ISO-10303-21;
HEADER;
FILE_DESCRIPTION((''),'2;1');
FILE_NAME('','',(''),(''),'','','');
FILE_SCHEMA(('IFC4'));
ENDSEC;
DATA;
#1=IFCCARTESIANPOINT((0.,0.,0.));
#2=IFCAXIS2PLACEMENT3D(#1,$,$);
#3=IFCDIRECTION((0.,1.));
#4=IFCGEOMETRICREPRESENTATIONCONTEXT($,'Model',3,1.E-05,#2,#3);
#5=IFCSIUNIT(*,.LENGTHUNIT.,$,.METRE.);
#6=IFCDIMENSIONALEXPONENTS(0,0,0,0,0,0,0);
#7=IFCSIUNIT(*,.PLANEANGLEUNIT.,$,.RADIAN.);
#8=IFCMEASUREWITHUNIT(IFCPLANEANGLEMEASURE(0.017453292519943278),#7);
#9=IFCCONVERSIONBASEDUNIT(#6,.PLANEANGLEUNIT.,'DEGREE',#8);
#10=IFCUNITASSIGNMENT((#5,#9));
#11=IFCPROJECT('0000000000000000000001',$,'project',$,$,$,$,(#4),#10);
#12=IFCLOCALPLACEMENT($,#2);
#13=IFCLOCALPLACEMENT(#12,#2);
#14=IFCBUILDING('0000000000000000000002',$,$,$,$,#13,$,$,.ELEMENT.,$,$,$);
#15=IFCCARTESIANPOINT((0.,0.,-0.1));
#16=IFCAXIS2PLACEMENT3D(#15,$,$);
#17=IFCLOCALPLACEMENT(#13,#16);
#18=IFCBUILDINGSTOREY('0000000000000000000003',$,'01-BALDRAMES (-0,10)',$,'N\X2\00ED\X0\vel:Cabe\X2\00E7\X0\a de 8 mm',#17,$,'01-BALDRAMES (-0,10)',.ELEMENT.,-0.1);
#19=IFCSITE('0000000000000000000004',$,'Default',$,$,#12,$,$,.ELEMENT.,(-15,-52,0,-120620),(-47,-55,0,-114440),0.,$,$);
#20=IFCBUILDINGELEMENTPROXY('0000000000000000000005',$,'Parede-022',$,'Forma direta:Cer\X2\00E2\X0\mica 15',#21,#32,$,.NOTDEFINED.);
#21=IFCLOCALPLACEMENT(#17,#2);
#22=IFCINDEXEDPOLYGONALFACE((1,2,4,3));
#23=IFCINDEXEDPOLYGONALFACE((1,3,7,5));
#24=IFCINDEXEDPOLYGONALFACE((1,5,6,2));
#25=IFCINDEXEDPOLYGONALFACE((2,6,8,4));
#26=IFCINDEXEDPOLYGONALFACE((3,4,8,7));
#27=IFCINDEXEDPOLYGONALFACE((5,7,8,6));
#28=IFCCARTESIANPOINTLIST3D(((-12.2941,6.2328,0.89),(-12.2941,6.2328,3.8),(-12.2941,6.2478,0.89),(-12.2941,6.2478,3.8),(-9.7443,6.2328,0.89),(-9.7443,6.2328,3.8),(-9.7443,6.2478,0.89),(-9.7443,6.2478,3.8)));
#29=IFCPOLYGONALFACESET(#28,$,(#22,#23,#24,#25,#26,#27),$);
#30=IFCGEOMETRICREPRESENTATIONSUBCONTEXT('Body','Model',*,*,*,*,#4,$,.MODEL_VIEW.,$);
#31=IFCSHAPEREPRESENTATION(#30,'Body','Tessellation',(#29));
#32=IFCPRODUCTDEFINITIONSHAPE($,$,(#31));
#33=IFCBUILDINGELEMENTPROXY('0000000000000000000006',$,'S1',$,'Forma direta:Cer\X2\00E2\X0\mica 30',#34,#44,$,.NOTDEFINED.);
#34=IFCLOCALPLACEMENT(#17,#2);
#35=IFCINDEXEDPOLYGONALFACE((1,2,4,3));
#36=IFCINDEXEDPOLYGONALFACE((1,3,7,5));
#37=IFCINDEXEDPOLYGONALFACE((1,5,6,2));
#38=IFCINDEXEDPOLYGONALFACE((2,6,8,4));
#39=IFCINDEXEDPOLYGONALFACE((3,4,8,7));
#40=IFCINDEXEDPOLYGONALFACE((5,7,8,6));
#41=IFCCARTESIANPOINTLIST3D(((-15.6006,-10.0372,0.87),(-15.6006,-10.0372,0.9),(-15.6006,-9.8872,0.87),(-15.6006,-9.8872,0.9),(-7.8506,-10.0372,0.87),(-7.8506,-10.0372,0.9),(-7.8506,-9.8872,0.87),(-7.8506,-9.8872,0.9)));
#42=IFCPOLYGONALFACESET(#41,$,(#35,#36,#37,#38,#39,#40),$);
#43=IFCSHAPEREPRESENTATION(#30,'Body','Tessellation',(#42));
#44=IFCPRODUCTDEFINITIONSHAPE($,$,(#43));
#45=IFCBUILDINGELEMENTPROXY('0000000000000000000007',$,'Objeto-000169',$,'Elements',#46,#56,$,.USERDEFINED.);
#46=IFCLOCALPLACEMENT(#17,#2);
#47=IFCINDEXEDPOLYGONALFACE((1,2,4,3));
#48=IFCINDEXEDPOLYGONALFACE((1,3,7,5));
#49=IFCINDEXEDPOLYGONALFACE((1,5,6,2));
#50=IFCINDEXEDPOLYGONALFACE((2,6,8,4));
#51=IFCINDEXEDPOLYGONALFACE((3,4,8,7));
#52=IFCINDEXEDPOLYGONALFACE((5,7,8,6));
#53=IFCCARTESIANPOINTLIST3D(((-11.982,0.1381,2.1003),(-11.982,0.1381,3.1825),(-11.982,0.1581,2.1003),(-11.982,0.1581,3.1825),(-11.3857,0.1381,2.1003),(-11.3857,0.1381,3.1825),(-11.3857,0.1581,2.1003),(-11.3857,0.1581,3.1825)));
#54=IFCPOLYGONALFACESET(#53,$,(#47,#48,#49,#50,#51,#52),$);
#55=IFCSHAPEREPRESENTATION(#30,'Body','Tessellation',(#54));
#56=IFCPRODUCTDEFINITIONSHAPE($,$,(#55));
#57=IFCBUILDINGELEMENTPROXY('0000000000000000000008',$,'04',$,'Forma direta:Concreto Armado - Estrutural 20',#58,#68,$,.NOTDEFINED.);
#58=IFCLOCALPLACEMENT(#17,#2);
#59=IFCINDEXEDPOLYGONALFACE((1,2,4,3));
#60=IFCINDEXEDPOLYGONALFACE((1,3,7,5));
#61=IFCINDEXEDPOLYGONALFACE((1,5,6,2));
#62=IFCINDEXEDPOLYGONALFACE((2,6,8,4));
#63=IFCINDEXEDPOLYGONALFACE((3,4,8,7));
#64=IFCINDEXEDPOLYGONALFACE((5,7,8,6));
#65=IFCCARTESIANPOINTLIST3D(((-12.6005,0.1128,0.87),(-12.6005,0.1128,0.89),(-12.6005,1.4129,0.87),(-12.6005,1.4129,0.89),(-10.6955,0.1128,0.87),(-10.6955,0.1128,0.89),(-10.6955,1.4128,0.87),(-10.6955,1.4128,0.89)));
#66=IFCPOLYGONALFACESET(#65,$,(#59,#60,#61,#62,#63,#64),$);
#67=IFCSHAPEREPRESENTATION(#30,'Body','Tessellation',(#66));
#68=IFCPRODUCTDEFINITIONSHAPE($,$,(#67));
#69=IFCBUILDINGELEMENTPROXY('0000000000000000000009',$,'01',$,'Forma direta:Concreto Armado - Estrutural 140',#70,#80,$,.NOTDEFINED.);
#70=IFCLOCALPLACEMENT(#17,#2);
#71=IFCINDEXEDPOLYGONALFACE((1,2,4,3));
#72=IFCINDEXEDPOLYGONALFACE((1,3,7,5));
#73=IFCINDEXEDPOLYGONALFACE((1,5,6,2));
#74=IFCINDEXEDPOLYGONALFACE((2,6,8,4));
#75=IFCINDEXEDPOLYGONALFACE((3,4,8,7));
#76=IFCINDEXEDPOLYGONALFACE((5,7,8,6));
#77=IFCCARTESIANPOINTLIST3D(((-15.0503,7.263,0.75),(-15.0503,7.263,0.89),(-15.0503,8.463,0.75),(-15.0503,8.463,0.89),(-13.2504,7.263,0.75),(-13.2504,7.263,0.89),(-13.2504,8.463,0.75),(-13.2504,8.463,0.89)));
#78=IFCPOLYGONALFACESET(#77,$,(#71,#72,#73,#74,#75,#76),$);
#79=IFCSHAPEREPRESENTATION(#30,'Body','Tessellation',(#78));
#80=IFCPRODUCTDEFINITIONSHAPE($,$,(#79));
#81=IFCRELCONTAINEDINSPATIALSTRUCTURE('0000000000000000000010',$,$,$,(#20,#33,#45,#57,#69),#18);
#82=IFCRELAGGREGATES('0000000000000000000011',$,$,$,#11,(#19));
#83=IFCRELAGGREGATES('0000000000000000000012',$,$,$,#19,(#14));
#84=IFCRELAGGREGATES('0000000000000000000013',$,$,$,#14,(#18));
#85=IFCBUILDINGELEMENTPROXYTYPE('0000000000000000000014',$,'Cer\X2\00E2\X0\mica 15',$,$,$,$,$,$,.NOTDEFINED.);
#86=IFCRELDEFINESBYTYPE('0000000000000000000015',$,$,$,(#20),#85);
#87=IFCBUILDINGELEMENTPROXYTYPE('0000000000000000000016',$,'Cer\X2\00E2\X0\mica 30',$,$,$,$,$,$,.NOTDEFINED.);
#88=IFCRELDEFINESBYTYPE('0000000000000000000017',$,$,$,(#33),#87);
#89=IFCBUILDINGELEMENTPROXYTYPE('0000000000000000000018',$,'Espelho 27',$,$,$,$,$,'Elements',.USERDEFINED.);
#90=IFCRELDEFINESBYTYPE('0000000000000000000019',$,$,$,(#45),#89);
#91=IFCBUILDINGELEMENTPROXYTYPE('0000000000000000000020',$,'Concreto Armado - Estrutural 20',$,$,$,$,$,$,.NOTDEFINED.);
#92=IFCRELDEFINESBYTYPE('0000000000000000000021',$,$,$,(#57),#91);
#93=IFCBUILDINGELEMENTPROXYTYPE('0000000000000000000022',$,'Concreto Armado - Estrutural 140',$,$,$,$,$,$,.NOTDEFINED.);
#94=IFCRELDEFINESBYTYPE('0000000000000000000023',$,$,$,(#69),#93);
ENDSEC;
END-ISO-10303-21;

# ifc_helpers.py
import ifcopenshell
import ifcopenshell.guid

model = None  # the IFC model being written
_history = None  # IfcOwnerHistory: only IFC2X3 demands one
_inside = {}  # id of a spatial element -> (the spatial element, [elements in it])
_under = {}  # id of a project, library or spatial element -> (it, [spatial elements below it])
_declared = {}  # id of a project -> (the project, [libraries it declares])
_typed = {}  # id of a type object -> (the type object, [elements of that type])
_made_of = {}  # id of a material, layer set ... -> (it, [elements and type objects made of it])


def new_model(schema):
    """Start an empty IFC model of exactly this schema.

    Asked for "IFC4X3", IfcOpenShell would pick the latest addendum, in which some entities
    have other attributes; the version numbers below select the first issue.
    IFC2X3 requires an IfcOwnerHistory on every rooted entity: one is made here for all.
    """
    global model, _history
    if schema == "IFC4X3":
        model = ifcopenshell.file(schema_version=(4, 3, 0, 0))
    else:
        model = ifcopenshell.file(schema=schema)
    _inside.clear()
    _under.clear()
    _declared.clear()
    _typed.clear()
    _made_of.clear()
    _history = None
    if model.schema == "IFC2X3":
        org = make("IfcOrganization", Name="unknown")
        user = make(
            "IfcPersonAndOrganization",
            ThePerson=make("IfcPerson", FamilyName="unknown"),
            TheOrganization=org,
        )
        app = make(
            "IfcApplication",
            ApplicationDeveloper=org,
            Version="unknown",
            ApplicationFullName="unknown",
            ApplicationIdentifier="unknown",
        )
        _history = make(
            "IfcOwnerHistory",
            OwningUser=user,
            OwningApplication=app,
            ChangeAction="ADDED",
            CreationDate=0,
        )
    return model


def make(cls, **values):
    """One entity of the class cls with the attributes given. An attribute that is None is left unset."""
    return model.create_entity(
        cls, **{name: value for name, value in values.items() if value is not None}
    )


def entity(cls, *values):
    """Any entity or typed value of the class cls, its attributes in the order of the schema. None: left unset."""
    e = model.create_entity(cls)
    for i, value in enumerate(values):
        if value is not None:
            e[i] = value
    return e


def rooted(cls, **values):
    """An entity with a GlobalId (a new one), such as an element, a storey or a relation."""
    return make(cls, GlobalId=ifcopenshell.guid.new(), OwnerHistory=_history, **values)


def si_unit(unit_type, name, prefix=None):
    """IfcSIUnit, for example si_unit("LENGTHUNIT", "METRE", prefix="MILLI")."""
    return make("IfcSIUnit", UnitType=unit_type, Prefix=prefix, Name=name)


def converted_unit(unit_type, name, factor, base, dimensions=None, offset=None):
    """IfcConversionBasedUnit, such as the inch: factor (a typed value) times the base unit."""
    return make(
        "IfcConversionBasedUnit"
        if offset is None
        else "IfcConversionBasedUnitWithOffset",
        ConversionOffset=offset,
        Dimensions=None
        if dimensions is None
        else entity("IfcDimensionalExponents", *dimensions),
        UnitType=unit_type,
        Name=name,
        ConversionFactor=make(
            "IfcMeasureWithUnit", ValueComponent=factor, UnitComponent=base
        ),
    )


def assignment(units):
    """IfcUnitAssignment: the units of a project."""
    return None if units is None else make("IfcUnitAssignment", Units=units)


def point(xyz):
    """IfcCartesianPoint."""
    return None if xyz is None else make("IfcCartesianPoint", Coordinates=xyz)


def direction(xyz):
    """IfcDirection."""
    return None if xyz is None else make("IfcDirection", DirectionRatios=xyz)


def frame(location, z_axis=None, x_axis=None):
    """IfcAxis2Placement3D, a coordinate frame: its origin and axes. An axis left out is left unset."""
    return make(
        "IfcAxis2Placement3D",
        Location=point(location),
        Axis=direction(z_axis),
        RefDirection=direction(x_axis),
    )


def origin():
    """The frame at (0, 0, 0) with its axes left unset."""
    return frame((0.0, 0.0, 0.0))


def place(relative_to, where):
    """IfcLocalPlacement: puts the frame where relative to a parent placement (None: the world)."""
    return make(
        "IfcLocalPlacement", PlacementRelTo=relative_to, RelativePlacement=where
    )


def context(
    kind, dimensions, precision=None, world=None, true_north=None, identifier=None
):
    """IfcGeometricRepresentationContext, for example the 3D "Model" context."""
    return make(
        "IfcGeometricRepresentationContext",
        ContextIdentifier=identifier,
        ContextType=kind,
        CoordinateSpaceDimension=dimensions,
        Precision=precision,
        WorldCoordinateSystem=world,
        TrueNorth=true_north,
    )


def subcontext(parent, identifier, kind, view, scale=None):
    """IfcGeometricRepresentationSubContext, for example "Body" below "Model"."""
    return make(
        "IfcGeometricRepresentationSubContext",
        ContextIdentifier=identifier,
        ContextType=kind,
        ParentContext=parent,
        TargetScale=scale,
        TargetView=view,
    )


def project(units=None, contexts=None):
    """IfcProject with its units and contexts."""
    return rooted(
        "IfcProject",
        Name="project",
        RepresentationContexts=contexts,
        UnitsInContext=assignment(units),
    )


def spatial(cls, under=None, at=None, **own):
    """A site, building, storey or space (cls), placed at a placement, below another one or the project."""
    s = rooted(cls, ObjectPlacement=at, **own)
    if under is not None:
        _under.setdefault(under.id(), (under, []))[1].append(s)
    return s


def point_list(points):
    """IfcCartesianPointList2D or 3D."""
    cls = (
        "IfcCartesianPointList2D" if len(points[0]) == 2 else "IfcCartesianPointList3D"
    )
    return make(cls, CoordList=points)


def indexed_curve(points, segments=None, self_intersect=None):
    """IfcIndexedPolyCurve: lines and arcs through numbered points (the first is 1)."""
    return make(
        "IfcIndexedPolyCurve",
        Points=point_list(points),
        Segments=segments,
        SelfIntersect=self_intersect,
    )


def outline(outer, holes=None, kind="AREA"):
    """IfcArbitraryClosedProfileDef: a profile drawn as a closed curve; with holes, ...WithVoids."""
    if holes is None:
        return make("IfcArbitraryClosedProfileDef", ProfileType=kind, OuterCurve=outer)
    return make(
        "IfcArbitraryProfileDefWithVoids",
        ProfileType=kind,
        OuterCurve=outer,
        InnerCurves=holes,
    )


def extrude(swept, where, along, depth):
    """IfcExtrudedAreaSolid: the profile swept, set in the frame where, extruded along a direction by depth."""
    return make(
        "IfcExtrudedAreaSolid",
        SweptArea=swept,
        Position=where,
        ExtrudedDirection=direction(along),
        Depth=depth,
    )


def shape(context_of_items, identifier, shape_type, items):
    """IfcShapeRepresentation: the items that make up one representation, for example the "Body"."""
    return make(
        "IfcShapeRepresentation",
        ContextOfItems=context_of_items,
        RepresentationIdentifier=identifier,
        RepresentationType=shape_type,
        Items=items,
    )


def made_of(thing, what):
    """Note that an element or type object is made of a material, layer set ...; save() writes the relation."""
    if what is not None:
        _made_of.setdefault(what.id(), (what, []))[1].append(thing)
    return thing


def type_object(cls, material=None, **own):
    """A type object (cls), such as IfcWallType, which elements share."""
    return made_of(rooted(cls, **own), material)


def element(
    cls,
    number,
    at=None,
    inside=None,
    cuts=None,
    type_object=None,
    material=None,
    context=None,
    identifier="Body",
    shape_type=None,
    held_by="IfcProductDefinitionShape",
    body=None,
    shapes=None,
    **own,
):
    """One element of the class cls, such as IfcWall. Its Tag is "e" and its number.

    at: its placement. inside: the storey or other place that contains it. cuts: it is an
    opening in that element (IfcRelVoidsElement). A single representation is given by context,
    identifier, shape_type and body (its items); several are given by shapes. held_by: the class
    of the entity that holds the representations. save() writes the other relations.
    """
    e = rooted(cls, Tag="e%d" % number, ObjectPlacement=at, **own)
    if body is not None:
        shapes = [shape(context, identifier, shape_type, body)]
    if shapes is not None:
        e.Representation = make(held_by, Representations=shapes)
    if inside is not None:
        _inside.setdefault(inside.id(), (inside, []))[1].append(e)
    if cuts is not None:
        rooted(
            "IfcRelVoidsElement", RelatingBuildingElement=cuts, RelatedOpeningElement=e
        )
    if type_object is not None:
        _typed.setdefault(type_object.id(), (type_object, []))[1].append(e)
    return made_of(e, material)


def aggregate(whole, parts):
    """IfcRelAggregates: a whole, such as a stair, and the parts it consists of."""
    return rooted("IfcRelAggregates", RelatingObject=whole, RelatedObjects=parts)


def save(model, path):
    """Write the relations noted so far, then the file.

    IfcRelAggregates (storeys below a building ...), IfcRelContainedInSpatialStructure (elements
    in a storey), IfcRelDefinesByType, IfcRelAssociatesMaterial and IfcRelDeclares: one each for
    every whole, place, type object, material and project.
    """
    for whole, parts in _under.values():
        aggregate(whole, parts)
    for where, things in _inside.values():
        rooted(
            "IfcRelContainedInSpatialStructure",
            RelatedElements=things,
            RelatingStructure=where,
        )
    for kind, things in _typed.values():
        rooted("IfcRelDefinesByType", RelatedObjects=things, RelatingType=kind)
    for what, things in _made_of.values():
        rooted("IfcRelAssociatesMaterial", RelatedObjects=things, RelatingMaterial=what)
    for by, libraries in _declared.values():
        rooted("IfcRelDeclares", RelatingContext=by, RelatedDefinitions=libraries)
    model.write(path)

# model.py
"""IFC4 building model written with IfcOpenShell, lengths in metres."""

from ifc_helpers import new_model, entity, si_unit, converted_unit, direction, frame, origin, place, context, subcontext, project, spatial, indexed_curve, outline, extrude, type_object, element, save


model = new_model("IFC4")

# Units and contexts
model_context = context("Model", 3, precision=1e-05, world=origin(), true_north=direction((0.0, 1.0)))
body_context = subcontext(model_context, "Body", "Model", "MODEL_VIEW")
ifc_project = project(units=[si_unit("LENGTHUNIT", "METRE"), converted_unit("PLANEANGLEUNIT", "DEGREE", entity("IfcPlaneAngleMeasure", 0.017453292519943278), si_unit("PLANEANGLEUNIT", "RADIAN"), dimensions=[0, 0, 0, 0, 0, 0, 0])], contexts=[model_context])

# Site, building, storey
site_placement = place(None, origin())
site = spatial("IfcSite", under=ifc_project, at=site_placement, Name="Default", CompositionType="ELEMENT", RefLatitude=(-15, -52, 0, -120620), RefLongitude=(-47, -55, 0, -114440), RefElevation=0.0)
building_placement = place(site_placement, origin())
building = spatial("IfcBuilding", under=site, at=building_placement, CompositionType="ELEMENT")
storey_placement = place(building_placement, frame((0.0, 0.0, -0.1)))
storey = spatial("IfcBuildingStorey", under=building, at=storey_placement, Name="01-BALDRAMES (-0,10)", ObjectType="Nível:Cabeça de 8 mm", LongName="01-BALDRAMES (-0,10)", CompositionType="ELEMENT", Elevation=-0.1)

# Building element proxies
building_element_proxy_type_1 = type_object("IfcBuildingElementProxyType", Name="Cerâmica 15", PredefinedType="NOTDEFINED")
proxy_1_placement = place(storey_placement, origin())
element("IfcBuildingElementProxy", 1, at=proxy_1_placement, inside=storey, type_object=building_element_proxy_type_1, Name="Parede-022", ObjectType="Forma direta:Cerâmica 15", PredefinedType="NOTDEFINED", context=body_context, shape_type="SweptSolid", body=[
    extrude(outline(indexed_curve([(-0.0075, -1.2749), (0.0075, -1.2749), (0.0075, 1.2749), (-0.0075, 1.2749), (-0.0075, -1.2749)], self_intersect=False)), frame((-11.0192, 6.2403, 0.89), z_axis=(0.0, 0.0, 1.0), x_axis=(-0.000013, -1.0, 0.0)), (0.0, 0.0, 1.0), 2.91),
])
building_element_proxy_type_2 = type_object("IfcBuildingElementProxyType", Name="Cerâmica 30", PredefinedType="NOTDEFINED")
proxy_2_placement = place(storey_placement, origin())
element("IfcBuildingElementProxy", 2, at=proxy_2_placement, inside=storey, type_object=building_element_proxy_type_2, Name="S1", ObjectType="Forma direta:Cerâmica 30", PredefinedType="NOTDEFINED", context=body_context, shape_type="SweptSolid", body=[
    extrude(outline(indexed_curve([(-3.875, -0.075), (3.875, -0.075), (3.875, 0.075), (-3.875, 0.075), (-3.875, -0.075)], self_intersect=False)), frame((-11.7256, -9.9622, 0.87)), (0.0, 0.0, 1.0), 0.03),
])
building_element_proxy_type_3 = type_object("IfcBuildingElementProxyType", Name="Espelho 27", ElementType="Elements", PredefinedType="USERDEFINED")
proxy_3_placement = place(storey_placement, origin())
element("IfcBuildingElementProxy", 3, at=proxy_3_placement, inside=storey, type_object=building_element_proxy_type_3, Name="Objeto-000169", ObjectType="Elements", PredefinedType="USERDEFINED", context=body_context, shape_type="SweptSolid", body=[
    extrude(outline(indexed_curve([(-0.01, -0.2981), (0.01, -0.2981), (0.01, 0.2981), (-0.01, 0.2981), (-0.01, -0.2981)], self_intersect=False)), frame((-11.6839, 0.1481, 2.1003), z_axis=(0.0, 0.0, 1.0), x_axis=(0.000009, 1.0, 0.0)), (0.0, 0.0, 1.0), 1.0822),
])
building_element_proxy_type_4 = type_object("IfcBuildingElementProxyType", Name="Concreto Armado - Estrutural 20", PredefinedType="NOTDEFINED")
proxy_4_placement = place(storey_placement, origin())
element("IfcBuildingElementProxy", 4, at=proxy_4_placement, inside=storey, type_object=building_element_proxy_type_4, Name="04", ObjectType="Forma direta:Concreto Armado - Estrutural 20", PredefinedType="NOTDEFINED", context=body_context, shape_type="SweptSolid", body=[
    extrude(outline(indexed_curve([(-0.65, -0.9525), (0.65, -0.9525), (0.65, 0.9525), (-0.65, 0.9525), (-0.65, -0.9525)], self_intersect=False)), frame((-11.648, 0.7628, 0.87), z_axis=(0.0, 0.0, 1.0), x_axis=(0.000013, 1.0, 0.0)), (0.0, 0.0, 1.0), 0.02),
])
building_element_proxy_type_5 = type_object("IfcBuildingElementProxyType", Name="Concreto Armado - Estrutural 140", PredefinedType="NOTDEFINED")
proxy_5_placement = place(storey_placement, origin())
element("IfcBuildingElementProxy", 5, at=proxy_5_placement, inside=storey, type_object=building_element_proxy_type_5, Name="01", ObjectType="Forma direta:Concreto Armado - Estrutural 140", PredefinedType="NOTDEFINED", context=body_context, shape_type="SweptSolid", body=[
    extrude(outline(indexed_curve([(-0.9, -0.6), (0.9, -0.6), (0.9, 0.6), (-0.9, 0.6), (-0.9, -0.6)], self_intersect=False)), frame((-14.1504, 7.863, 0.75)), (0.0, 0.0, 1.0), 0.14),
])

save(model, "model.ifc")
